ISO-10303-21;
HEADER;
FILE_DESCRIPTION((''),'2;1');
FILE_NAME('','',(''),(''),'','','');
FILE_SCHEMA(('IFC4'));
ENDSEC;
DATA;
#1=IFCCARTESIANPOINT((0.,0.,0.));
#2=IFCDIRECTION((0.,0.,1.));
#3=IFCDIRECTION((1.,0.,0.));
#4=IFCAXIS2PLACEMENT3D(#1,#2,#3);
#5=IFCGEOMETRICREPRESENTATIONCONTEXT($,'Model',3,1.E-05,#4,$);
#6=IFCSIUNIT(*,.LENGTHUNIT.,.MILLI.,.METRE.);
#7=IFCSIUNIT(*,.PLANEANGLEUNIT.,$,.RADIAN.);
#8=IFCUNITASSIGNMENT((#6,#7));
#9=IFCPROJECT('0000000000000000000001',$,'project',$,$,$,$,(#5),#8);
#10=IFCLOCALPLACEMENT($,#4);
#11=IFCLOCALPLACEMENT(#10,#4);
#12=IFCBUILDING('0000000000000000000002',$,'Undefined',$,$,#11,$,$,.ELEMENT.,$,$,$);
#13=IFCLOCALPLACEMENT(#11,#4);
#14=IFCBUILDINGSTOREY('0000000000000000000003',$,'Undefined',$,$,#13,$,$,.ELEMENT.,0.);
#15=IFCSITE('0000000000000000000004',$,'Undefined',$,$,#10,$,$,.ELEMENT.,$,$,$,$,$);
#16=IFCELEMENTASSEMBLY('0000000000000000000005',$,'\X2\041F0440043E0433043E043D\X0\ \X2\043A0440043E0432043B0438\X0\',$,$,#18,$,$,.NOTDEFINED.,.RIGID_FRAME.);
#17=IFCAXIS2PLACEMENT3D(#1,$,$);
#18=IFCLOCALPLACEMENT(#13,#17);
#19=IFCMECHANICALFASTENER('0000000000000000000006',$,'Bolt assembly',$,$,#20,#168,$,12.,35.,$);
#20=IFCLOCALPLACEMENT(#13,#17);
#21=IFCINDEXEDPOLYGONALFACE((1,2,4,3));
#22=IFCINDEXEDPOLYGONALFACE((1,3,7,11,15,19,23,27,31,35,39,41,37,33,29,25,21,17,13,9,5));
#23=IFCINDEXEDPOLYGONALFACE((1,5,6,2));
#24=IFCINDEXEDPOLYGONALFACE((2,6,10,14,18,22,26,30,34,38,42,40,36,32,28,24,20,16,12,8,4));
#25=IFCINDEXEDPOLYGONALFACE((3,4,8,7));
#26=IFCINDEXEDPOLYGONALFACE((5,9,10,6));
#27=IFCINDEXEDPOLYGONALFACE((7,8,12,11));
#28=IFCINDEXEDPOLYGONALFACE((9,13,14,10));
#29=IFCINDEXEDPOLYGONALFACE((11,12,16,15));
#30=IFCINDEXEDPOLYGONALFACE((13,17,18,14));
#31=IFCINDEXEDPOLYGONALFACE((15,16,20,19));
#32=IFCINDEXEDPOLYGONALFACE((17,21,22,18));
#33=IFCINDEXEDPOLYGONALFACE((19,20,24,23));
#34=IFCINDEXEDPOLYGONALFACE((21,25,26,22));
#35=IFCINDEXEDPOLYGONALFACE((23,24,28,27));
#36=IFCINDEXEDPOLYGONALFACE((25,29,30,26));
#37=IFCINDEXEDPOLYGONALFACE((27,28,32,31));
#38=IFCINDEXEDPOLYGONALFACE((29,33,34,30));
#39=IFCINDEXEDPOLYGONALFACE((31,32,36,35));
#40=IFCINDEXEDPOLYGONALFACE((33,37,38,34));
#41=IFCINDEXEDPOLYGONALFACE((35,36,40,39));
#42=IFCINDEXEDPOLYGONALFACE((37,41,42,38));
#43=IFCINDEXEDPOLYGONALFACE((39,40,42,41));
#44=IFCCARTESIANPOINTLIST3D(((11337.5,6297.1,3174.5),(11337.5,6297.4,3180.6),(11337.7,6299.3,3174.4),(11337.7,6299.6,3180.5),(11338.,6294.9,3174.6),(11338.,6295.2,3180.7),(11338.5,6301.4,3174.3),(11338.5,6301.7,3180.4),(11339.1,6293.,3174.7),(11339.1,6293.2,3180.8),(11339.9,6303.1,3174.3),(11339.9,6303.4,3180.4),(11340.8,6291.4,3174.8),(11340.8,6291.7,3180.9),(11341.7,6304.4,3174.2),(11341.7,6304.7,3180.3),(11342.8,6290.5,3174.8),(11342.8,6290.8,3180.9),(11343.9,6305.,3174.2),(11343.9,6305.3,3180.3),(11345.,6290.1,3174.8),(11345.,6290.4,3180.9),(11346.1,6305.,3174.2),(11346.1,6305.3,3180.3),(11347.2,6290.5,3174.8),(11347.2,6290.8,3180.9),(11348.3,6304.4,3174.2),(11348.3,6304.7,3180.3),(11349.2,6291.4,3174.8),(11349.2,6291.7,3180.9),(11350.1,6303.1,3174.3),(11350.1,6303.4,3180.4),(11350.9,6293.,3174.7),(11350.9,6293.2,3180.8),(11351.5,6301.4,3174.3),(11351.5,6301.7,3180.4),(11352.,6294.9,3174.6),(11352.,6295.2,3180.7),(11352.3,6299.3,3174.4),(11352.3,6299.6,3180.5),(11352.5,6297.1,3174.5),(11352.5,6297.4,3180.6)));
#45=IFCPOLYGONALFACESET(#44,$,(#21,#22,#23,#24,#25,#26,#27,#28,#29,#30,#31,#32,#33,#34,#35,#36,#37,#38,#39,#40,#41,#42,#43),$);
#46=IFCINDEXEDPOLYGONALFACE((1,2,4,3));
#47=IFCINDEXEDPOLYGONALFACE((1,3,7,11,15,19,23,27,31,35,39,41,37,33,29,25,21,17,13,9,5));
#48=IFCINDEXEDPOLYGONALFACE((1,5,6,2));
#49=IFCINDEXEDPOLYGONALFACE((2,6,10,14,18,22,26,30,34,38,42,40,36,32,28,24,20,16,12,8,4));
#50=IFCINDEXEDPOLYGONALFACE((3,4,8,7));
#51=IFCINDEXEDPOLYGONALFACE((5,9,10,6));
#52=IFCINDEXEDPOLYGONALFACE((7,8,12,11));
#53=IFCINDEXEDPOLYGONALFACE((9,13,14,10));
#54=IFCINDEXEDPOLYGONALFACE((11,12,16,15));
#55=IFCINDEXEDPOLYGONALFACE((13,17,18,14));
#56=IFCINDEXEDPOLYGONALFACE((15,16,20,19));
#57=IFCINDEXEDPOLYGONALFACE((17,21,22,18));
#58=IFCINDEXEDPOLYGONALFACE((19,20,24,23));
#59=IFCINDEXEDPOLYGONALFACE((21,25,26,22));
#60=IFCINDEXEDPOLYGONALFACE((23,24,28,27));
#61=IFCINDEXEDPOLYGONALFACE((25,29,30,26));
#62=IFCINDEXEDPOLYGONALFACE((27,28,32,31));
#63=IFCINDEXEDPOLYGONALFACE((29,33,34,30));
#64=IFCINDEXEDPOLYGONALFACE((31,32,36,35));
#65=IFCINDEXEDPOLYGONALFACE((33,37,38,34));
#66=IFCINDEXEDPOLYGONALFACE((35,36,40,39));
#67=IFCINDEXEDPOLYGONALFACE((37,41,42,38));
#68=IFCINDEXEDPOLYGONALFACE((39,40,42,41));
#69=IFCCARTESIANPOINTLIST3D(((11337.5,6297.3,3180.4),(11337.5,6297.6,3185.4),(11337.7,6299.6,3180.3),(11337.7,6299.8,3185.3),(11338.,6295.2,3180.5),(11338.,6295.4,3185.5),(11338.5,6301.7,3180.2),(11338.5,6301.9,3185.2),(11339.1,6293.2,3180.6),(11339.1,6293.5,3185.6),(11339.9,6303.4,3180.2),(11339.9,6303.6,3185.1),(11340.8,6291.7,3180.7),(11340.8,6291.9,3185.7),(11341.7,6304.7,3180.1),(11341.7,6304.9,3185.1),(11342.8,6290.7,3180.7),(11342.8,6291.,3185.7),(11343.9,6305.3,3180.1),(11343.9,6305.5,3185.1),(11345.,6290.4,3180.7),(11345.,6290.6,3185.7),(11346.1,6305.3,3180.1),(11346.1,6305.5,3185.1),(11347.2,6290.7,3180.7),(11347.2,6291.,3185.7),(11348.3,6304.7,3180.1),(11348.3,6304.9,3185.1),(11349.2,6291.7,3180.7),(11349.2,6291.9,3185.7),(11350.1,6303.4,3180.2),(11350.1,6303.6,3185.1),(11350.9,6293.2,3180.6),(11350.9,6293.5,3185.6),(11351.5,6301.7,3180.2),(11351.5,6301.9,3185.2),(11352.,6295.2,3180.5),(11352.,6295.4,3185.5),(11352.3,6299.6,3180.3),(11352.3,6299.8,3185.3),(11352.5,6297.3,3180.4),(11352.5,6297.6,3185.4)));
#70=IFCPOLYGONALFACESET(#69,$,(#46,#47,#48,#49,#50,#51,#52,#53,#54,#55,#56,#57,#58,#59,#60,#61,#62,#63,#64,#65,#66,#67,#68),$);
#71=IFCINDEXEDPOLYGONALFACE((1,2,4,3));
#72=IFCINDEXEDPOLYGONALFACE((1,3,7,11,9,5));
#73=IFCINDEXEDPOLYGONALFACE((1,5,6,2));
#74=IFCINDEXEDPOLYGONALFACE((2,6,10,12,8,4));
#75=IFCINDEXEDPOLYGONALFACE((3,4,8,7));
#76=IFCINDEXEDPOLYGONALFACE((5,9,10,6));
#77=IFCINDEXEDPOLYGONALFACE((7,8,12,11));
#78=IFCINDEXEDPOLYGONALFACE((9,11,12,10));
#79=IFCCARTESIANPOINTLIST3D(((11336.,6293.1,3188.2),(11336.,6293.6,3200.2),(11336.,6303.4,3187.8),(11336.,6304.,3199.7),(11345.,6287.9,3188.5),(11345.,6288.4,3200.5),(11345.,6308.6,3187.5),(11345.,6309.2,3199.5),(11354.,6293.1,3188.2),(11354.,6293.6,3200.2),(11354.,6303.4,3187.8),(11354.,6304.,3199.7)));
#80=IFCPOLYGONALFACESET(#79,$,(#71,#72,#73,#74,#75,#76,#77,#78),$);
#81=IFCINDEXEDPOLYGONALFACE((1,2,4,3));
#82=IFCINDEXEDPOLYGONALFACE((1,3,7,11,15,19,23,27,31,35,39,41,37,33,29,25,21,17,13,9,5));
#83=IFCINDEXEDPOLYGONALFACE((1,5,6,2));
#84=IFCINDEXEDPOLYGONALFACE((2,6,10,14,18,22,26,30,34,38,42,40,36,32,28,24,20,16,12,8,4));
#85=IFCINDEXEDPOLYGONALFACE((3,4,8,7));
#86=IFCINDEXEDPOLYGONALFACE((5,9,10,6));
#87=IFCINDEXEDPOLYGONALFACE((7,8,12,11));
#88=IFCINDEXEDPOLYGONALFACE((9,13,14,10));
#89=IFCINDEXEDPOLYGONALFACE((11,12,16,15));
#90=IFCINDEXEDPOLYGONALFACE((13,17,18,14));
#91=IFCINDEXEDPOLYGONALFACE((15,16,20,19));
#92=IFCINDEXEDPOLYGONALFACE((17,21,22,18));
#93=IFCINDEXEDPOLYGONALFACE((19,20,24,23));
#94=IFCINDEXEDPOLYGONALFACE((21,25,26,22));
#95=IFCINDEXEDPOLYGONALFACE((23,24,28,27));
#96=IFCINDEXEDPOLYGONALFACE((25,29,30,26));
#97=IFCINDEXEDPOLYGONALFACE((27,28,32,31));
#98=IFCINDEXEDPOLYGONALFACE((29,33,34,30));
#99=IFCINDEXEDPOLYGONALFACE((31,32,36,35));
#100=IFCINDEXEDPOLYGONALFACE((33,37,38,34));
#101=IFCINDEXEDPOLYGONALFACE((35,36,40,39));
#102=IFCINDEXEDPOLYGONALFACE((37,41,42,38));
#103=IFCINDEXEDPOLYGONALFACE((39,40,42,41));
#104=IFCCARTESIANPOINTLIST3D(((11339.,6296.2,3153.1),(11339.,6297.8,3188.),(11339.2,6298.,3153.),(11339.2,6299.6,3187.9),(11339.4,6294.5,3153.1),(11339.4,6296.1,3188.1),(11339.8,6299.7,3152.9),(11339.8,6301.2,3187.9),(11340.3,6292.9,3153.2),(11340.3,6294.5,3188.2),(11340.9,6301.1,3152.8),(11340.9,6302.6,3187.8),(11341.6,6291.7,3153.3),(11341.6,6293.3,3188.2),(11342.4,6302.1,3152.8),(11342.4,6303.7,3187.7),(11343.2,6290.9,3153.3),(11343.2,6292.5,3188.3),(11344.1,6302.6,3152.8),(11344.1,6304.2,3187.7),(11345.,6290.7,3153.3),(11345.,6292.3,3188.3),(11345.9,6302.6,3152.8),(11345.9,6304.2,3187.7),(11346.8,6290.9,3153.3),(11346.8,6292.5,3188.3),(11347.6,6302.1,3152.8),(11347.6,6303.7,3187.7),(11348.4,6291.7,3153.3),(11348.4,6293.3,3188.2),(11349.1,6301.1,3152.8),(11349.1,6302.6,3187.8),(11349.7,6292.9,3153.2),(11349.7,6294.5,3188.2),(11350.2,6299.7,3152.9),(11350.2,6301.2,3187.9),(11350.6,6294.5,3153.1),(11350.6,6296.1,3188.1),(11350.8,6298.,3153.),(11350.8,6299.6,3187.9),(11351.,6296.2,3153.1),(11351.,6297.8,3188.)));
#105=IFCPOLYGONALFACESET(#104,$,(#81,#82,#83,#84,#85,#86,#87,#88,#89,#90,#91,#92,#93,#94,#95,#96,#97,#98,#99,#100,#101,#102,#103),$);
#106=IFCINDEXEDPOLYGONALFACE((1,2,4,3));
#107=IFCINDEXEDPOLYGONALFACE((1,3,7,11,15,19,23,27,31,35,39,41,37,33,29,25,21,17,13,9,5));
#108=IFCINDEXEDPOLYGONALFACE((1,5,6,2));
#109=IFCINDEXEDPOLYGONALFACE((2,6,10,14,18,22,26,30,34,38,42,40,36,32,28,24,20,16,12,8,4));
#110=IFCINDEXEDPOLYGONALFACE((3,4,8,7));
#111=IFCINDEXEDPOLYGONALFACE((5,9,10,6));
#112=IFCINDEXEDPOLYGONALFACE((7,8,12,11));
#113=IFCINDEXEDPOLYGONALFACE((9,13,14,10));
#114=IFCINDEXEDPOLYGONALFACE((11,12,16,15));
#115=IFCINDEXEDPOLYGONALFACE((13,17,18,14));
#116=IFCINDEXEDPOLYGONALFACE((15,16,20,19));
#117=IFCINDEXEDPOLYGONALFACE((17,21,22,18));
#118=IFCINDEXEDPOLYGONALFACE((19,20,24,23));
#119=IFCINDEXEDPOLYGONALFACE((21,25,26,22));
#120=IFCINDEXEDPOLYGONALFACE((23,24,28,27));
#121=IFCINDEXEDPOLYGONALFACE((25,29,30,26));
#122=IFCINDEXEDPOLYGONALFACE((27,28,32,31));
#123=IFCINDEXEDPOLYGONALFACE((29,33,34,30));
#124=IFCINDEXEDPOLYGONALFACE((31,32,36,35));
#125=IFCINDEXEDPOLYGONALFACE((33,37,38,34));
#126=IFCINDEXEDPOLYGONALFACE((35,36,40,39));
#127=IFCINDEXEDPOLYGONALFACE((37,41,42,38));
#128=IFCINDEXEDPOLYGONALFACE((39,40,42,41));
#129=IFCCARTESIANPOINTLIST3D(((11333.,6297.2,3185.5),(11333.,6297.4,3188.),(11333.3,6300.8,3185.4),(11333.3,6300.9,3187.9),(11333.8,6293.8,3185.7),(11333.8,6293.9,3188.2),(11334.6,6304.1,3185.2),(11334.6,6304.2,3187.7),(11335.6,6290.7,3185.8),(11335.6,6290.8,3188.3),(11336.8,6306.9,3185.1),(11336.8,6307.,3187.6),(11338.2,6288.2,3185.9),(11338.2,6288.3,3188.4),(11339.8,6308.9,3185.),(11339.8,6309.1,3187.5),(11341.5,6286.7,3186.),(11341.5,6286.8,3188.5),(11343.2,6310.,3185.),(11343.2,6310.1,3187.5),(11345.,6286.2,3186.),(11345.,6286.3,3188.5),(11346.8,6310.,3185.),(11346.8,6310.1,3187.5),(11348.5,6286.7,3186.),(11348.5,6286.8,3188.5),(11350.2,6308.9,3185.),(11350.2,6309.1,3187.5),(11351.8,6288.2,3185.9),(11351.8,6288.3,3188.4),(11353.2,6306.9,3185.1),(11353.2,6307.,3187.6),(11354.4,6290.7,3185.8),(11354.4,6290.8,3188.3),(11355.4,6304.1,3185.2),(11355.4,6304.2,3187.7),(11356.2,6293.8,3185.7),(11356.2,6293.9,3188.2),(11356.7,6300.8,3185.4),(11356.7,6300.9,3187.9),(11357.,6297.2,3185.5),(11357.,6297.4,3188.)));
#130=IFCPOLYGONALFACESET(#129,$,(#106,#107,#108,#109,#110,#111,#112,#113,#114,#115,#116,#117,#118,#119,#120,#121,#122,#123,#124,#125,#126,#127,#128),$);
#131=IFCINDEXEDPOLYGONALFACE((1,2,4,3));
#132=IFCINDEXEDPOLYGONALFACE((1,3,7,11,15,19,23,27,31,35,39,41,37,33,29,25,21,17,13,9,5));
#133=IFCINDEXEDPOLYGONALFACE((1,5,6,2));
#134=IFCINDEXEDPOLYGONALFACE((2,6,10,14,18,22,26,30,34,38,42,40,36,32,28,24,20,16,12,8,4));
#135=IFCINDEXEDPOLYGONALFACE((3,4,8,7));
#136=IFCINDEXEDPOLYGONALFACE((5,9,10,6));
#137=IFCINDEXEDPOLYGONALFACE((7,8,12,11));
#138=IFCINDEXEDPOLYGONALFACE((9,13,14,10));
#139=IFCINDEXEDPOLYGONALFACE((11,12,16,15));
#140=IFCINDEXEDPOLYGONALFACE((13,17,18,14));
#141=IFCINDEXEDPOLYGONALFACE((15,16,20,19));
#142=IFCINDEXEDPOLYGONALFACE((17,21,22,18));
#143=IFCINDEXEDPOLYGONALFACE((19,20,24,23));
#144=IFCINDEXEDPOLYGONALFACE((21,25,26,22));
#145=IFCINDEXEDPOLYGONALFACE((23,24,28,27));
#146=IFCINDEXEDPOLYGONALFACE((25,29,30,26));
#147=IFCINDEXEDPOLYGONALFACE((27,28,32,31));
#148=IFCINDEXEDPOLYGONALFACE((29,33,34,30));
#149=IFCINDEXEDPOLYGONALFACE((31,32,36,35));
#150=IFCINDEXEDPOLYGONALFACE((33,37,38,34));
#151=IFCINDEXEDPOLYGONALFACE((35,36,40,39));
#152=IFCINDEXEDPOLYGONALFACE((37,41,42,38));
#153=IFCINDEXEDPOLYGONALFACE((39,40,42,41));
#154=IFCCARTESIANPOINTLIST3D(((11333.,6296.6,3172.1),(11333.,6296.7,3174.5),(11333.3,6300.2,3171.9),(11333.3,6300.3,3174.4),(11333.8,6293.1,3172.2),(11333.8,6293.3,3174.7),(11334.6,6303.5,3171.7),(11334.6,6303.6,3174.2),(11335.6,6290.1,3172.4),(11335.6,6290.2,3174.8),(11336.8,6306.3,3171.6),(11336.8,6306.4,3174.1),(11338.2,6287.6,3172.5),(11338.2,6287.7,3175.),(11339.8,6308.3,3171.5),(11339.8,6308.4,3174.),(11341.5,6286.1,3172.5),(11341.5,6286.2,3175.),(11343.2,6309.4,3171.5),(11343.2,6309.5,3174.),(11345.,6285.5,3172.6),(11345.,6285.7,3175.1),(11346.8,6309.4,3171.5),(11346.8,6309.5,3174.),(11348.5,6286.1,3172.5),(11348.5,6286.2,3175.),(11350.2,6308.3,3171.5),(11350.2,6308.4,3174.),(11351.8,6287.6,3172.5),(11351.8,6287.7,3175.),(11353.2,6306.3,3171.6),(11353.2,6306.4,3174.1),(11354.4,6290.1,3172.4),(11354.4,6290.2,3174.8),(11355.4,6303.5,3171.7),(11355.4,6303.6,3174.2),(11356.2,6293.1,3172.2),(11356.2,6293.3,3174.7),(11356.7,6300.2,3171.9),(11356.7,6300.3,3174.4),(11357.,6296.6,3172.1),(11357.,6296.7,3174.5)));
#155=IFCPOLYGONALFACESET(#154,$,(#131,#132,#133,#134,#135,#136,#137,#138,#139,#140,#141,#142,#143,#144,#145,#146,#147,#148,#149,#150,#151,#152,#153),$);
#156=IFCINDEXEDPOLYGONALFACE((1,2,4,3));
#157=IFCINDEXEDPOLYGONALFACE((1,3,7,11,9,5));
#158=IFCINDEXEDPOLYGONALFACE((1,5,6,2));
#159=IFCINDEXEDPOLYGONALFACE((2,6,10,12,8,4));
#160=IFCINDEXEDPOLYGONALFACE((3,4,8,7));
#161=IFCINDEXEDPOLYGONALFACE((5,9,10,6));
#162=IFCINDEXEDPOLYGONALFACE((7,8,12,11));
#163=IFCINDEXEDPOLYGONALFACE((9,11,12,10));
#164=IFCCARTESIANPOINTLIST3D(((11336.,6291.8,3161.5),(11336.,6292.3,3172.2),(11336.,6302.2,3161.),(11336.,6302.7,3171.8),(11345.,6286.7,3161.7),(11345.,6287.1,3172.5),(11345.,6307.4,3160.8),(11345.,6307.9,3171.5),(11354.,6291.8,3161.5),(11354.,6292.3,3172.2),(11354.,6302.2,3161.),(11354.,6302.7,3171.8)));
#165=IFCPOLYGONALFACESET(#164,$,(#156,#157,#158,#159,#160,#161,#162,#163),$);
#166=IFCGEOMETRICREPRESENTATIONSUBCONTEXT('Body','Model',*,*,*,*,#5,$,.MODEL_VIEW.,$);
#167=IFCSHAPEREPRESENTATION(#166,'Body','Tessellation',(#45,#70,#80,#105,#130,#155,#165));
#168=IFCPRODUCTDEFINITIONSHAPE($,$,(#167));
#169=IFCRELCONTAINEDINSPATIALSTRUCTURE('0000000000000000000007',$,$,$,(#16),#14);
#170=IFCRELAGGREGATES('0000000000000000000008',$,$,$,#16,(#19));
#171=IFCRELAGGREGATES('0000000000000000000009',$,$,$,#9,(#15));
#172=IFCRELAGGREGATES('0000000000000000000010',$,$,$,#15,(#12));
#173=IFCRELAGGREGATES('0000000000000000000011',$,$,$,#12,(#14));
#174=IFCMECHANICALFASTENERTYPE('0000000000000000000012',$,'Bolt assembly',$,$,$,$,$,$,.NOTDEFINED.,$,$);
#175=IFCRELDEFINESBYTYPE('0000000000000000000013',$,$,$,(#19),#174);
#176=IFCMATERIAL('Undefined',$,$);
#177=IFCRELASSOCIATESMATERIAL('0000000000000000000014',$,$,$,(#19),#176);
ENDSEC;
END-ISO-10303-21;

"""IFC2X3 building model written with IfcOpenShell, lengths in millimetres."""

from ifc_helpers import new_model, si_unit, frame, origin_with_axes, origin_2d_with_axis, place, context, subcontext, project, spatial, polyline, circle, outline, extrude, source, transform, mapped, material, type_object, element, aggregate, save


model = new_model("IFC2X3")

# Units and contexts
model_context = context("Model", 3, precision=1e-05, world=origin_with_axes())
body_context = subcontext(model_context, "Body", "Model", "MODEL_VIEW")
ifc_project = project(units=[si_unit("LENGTHUNIT", "METRE", prefix="MILLI"), si_unit("PLANEANGLEUNIT", "RADIAN")], contexts=[model_context])

# Site, building, storey
site_placement = place(None, origin_with_axes())
site = spatial("IfcSite", under=ifc_project, at=site_placement, Name="Undefined", CompositionType="ELEMENT")
building_placement = place(site_placement, origin_with_axes())
building = spatial("IfcBuilding", under=site, at=building_placement, Name="Undefined", CompositionType="ELEMENT")
storey_placement = place(building_placement, origin_with_axes())
storey = spatial("IfcBuildingStorey", under=building, at=storey_placement, Name="Undefined", CompositionType="ELEMENT", Elevation=0.0)

# Element assembly
assembly_1_placement = place(storey_placement, origin_with_axes())
assembly_1 = element("IfcElementAssembly", 1, at=assembly_1_placement, inside=storey, Name="Прогон кровли", AssemblyPlace="NOTDEFINED", PredefinedType="RIGID_FRAME")

# Mechanical fastener
ifc_material_1 = material(Name="Undefined")
mechanical_fastener_type = type_object("IfcMechanicalFastenerType", Name="Bolt assembly")
shared_shape_1 = source(origin_with_axes(), body_context, "Body", "SweptSolid", [
    extrude(circle(Radius=7.5, at=origin_2d_with_axis()), frame((0.0, -0.1, 0.0), z_axis=(0.0, 1.0, 0.0), x_axis=(1.0, 0.0, 0.0)), (0.0, 0.0, 1.0), 6.1),
    extrude(circle(Radius=7.5, at=origin_2d_with_axis()), frame((0.0, -4.9, 0.0), z_axis=(0.0, 1.0, 0.0), x_axis=(1.0, 0.0, 0.0)), (0.0, 0.0, 1.0), 5.0),
    extrude(outline(polyline([(10.4, 0.0), (5.2, 9.0), (-5.2, 9.0), (-10.4, 0.0), (-5.2, -9.0), (5.2, -9.0), (10.4, 0.0)])), frame((0.0, -19.5, 0.0), z_axis=(0.0, 1.0, 0.0), x_axis=(1.0, 0.0, 0.0)), (0.0, 0.0, 1.0), 12.0),
    extrude(circle(Radius=6.0, at=origin_2d_with_axis()), frame((0.0, -7.5, 0.0), z_axis=(0.0, 1.0, 0.0), x_axis=(1.0, 0.0, 0.0)), (0.0, 0.0, 1.0), 35.0),
    extrude(circle(Radius=12.0, at=origin_2d_with_axis()), frame((0.0, -7.5, 0.0), z_axis=(0.0, 1.0, 0.0), x_axis=(1.0, 0.0, 0.0)), (0.0, 0.0, 1.0), 2.5),
    extrude(circle(Radius=12.0, at=origin_2d_with_axis()), frame((0.0, 6.0, 0.0), z_axis=(0.0, 1.0, 0.0), x_axis=(1.0, 0.0, 0.0)), (0.0, 0.0, 1.0), 2.5),
    extrude(outline(polyline([(10.4, 0.0), (5.2, 9.0), (-5.2, 9.0), (-10.4, 0.0), (-5.2, -9.0), (5.2, -9.0), (10.4, 0.0)])), frame((0.0, 8.5, 0.0), z_axis=(0.0, 1.0, 0.0), x_axis=(1.0, 0.0, 0.0)), (0.0, 0.0, 1.0), 10.8),
])
mechanical_fastener_1_placement = place(assembly_1_placement, frame((11345.0, 6297.9, 3180.5), z_axis=(1.0, 0.0, 0.0), x_axis=(0.0, -0.998969, 0.045408)))
mechanical_fastener_1 = element("IfcMechanicalFastener", 2, at=mechanical_fastener_1_placement, type_object=mechanical_fastener_type, material=ifc_material_1, Name="Bolt assembly", NominalDiameter=12.0, NominalLength=35.0, context=body_context, shape_type="MappedRepresentation", body=[
    mapped(shared_shape_1, transform((0.0, 0.0, 0.0))),
])
aggregate(assembly_1, [mechanical_fastener_1])

save(model, "model.ifc")
